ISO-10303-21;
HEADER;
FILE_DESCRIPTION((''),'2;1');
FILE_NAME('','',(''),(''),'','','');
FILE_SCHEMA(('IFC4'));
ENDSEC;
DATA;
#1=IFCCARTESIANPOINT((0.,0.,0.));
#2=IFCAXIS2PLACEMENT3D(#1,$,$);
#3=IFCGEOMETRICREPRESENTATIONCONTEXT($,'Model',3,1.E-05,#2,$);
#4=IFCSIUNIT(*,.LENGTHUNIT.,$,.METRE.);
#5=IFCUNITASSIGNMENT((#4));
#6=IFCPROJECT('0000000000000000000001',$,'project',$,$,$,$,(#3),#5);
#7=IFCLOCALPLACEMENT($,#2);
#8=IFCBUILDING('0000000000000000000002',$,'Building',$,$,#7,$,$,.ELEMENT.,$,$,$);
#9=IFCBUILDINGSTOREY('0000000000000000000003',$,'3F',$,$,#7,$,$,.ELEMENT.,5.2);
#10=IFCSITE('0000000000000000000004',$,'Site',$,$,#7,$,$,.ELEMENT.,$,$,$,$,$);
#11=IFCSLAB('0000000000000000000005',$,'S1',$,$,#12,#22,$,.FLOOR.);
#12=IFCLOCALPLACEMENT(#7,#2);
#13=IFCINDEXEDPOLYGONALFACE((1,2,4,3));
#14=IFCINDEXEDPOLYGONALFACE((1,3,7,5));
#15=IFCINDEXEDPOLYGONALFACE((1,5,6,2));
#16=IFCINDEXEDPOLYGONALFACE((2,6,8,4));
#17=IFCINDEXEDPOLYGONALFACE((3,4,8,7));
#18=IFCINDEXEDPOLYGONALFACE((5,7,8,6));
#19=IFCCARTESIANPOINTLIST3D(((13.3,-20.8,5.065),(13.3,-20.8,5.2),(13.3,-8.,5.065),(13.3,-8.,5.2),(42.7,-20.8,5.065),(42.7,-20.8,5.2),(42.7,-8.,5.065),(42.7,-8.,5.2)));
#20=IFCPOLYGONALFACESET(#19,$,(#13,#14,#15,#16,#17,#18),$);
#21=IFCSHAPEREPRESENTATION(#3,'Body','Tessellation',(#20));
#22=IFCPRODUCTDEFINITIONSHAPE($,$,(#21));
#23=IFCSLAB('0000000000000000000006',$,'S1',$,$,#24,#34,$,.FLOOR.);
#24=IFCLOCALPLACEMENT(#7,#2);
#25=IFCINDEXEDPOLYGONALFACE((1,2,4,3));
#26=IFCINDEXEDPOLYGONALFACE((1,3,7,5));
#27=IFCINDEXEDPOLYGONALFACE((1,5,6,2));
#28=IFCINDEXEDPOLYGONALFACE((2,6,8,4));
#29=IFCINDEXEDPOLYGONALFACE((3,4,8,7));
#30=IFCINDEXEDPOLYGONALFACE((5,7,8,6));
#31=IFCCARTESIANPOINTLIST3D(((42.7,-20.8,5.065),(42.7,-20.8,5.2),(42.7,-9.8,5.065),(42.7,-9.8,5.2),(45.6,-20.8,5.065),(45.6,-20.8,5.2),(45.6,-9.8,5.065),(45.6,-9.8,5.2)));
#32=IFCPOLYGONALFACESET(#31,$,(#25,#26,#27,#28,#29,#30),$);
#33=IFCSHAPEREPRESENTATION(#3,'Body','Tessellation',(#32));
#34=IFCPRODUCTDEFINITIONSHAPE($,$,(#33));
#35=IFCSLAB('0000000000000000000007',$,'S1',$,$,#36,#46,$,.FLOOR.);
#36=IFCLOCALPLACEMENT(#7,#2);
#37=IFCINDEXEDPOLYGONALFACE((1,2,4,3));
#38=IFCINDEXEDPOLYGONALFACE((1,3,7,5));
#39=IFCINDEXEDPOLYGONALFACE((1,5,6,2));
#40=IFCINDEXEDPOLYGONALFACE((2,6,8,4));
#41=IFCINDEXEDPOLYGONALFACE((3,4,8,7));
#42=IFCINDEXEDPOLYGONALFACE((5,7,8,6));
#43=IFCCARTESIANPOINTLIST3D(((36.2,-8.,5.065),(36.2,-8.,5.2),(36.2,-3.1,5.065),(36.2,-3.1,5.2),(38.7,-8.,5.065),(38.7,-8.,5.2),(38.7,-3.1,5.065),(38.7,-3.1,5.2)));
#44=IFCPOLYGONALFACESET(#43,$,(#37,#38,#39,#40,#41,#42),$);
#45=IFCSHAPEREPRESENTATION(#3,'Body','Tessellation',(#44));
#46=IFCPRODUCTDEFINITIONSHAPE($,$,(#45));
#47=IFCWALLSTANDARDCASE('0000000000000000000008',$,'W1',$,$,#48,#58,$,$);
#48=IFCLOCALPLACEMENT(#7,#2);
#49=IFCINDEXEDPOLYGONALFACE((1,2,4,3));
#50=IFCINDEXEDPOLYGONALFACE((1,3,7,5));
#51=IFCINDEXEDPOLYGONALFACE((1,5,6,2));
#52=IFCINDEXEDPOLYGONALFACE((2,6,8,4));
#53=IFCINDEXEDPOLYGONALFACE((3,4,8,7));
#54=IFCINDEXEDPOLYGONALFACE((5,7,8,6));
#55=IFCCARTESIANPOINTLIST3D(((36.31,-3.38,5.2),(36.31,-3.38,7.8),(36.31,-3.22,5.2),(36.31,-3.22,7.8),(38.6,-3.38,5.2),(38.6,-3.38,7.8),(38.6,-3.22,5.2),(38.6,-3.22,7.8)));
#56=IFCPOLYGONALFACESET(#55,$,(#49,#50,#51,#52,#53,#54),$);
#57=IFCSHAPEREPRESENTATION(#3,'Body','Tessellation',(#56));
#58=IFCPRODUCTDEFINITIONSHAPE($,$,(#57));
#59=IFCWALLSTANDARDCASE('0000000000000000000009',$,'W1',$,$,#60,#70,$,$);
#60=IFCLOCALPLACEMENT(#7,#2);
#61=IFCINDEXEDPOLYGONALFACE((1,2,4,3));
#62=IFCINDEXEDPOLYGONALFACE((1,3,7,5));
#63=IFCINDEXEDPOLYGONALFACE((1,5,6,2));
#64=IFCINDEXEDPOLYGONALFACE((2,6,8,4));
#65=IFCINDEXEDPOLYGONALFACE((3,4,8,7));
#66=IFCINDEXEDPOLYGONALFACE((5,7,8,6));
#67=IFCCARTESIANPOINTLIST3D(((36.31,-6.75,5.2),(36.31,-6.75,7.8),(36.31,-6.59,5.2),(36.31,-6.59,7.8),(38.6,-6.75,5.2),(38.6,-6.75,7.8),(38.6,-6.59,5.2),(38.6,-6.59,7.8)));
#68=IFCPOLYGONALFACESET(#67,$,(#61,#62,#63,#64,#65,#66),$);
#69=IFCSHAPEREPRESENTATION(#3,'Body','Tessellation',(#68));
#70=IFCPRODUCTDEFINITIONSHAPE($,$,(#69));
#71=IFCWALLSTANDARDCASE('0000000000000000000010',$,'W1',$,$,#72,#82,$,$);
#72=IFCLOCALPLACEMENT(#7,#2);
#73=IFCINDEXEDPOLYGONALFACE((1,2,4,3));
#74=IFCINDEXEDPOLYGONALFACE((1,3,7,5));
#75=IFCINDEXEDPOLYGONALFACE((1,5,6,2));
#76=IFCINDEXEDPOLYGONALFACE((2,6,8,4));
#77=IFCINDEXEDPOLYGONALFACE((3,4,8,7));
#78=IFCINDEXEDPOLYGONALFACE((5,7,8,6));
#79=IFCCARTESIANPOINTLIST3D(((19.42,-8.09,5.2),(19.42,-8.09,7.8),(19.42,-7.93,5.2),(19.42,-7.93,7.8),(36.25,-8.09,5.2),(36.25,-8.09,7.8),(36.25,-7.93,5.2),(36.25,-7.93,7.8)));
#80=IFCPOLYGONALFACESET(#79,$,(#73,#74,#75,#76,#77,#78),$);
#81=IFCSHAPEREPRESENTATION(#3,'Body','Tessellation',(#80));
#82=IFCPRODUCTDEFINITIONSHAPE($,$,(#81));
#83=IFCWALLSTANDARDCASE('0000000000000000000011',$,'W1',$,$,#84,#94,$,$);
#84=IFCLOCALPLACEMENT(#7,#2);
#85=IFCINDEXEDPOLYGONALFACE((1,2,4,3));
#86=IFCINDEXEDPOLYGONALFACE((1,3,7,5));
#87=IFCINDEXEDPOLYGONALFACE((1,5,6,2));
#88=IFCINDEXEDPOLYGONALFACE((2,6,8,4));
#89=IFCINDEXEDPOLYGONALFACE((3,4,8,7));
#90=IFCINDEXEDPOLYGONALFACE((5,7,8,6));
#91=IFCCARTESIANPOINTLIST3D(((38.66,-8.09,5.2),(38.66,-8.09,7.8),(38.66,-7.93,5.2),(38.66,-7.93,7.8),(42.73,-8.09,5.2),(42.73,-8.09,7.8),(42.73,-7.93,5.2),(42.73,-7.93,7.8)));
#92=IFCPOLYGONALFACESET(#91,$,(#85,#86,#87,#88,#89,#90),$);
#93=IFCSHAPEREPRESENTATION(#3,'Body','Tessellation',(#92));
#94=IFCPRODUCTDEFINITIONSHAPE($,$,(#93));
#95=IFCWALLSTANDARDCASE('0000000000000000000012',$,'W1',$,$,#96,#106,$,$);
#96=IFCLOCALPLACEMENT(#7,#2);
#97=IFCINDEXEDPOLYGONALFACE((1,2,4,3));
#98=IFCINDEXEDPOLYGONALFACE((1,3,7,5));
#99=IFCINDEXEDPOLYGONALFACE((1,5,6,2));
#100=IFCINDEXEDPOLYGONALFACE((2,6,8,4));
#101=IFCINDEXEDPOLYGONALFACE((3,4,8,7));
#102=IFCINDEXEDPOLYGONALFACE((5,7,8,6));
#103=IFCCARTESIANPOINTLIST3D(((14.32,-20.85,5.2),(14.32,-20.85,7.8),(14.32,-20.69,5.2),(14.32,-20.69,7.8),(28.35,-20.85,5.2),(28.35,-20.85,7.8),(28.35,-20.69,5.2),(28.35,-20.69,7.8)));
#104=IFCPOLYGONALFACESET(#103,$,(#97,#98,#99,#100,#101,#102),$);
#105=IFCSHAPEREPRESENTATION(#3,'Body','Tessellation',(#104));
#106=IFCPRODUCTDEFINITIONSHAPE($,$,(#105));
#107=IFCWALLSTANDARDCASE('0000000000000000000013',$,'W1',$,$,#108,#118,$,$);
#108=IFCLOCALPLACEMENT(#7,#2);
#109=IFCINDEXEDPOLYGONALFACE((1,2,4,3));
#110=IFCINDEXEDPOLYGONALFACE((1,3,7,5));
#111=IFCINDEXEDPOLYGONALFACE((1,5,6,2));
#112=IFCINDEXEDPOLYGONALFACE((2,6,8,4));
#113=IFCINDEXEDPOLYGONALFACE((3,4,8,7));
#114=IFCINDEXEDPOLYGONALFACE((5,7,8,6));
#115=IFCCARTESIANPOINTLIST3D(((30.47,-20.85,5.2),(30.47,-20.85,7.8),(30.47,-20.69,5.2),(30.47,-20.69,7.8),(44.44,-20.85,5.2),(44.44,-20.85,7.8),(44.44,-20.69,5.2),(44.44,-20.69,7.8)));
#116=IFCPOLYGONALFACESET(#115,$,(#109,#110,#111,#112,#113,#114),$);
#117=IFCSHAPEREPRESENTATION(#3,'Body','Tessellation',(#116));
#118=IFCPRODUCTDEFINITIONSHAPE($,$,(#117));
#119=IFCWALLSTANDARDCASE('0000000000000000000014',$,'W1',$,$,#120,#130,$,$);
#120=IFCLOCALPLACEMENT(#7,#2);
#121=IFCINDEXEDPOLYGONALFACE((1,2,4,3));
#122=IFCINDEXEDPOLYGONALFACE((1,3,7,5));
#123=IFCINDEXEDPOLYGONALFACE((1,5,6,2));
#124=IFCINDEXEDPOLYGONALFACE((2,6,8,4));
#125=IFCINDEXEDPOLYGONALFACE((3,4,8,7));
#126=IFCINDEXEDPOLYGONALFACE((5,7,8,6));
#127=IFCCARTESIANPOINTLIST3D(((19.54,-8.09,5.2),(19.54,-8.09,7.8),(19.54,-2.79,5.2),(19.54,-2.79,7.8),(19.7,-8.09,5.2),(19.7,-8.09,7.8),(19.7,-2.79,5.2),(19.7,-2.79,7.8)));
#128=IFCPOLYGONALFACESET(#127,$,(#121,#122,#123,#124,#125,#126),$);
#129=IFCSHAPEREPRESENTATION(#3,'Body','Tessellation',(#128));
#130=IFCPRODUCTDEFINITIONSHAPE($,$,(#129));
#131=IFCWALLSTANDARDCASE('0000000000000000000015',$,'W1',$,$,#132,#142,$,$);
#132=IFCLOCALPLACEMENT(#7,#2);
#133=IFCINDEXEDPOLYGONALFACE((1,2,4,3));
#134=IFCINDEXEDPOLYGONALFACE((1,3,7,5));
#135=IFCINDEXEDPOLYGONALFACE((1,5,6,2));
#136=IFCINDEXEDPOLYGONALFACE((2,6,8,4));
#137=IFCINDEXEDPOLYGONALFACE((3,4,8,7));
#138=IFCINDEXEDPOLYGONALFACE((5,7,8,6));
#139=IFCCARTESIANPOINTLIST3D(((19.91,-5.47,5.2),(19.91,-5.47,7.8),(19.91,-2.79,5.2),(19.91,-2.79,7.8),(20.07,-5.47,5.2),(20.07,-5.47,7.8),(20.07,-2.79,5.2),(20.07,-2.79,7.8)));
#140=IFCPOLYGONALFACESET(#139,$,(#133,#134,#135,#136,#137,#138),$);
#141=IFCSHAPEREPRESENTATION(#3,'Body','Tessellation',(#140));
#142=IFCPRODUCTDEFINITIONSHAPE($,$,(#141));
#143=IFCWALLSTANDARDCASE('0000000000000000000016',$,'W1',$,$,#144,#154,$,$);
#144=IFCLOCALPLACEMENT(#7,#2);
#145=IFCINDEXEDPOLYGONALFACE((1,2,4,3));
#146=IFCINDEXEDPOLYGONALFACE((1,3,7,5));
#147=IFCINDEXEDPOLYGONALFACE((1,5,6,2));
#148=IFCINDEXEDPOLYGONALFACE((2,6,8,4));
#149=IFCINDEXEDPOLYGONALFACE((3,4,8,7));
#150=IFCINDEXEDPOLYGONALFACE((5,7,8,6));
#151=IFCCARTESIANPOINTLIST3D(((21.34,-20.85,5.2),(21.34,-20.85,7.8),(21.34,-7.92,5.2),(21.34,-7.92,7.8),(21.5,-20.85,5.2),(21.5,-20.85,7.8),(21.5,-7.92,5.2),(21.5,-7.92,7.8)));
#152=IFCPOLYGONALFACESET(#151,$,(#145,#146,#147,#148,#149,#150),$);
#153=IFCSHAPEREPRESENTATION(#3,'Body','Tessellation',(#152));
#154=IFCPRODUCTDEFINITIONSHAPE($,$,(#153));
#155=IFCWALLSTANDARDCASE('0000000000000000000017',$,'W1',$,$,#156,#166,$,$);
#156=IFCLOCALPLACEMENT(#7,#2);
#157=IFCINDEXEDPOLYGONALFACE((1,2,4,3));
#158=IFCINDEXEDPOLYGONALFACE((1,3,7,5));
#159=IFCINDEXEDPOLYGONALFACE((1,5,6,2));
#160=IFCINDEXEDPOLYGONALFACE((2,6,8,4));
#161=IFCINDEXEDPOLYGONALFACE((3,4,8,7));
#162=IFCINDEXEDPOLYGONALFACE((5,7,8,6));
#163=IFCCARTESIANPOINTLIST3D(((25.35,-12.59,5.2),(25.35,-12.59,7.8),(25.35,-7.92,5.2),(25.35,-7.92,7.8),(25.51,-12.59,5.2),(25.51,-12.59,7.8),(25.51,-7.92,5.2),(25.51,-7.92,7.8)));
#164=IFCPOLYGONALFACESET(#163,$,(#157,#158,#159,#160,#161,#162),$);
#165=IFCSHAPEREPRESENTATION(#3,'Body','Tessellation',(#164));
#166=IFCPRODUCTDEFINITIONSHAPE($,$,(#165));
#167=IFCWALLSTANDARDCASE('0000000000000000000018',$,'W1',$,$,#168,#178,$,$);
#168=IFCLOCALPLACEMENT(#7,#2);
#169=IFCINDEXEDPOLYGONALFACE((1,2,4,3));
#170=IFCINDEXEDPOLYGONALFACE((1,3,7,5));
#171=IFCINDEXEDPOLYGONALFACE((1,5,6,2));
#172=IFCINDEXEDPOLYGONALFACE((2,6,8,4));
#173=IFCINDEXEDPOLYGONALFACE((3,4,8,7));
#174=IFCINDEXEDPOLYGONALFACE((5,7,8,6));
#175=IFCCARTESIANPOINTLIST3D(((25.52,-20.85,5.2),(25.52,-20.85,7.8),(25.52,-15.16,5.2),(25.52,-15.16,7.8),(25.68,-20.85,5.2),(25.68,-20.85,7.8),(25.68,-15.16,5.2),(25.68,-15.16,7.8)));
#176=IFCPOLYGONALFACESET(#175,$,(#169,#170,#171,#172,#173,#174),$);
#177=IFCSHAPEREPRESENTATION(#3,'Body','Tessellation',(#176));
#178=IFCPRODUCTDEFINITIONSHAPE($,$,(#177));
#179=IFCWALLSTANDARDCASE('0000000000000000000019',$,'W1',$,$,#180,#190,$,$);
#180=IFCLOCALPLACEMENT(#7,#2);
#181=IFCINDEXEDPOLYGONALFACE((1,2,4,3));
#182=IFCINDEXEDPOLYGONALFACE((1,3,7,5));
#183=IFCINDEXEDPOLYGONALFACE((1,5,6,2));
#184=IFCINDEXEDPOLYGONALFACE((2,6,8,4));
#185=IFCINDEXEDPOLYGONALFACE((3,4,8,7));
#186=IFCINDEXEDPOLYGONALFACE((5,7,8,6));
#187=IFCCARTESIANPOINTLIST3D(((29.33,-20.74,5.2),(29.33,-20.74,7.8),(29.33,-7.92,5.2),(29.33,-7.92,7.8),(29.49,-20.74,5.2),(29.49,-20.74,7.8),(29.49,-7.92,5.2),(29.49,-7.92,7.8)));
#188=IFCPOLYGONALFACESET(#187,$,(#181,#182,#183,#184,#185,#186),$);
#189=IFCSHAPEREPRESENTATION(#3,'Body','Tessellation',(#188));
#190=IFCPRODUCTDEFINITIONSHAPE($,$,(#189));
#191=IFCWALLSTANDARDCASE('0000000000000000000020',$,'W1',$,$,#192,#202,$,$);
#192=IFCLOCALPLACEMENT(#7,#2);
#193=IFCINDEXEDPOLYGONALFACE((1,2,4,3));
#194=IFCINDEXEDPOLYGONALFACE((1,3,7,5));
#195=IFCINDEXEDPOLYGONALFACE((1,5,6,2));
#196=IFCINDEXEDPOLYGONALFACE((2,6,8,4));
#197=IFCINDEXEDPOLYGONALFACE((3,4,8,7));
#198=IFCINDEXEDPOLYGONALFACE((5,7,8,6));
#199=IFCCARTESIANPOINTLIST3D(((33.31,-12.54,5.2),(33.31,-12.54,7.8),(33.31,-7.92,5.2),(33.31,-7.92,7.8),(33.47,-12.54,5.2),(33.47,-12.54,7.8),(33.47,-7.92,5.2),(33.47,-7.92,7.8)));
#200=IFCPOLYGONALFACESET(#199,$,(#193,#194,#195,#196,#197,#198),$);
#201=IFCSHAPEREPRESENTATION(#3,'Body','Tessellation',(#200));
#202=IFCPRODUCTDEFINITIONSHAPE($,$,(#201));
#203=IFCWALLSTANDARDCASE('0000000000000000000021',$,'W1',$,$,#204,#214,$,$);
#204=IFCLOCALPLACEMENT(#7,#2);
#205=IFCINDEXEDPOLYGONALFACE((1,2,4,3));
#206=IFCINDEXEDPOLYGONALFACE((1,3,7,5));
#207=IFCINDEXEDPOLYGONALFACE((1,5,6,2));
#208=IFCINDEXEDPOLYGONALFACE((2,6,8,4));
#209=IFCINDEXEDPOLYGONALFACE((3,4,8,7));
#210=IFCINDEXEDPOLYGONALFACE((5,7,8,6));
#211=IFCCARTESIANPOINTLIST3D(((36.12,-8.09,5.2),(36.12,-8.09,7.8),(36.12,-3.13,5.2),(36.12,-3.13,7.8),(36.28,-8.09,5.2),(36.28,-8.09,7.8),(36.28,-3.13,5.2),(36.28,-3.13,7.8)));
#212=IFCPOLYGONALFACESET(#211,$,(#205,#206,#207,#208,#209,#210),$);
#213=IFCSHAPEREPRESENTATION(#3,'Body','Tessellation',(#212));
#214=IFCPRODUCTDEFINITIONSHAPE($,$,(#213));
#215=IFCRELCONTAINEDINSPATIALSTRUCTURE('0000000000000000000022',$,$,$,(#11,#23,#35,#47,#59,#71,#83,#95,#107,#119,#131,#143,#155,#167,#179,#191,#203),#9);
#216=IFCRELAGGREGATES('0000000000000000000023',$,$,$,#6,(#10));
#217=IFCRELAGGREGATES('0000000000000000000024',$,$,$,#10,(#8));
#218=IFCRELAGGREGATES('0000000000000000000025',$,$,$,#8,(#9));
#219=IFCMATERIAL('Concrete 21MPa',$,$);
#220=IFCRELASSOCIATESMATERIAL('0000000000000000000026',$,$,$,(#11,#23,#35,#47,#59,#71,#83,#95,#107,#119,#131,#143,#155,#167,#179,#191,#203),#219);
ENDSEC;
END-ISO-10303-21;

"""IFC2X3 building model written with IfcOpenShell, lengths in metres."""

from ifc_helpers import new_model, si_unit, frame, origin, origin_2d, place, context, project, spatial, rectangle, extrude, material, element, save


model = new_model("IFC2X3")

# Units and contexts
model_context = context("Model", 3, precision=1e-05, world=origin())
ifc_project = project(units=[si_unit("LENGTHUNIT", "METRE")], contexts=[model_context])

# Site, building, storey
placement = place(None, origin())
site = spatial("IfcSite", under=ifc_project, at=placement, Name="Site", CompositionType="ELEMENT")
building = spatial("IfcBuilding", under=site, at=placement, Name="Building", CompositionType="ELEMENT")
storey = spatial("IfcBuildingStorey", under=building, at=placement, Name="3F", CompositionType="ELEMENT", Elevation=5.2)

# Slabs
ifc_material_1 = material(Name="Concrete 21MPa")
slab_1_placement = place(None, frame((28.0, -14.4, 5.065)))
element("IfcSlab", 1, at=slab_1_placement, inside=storey, material=ifc_material_1, Name="S1", PredefinedType="FLOOR", context=model_context, shape_type="SweptSolid", body=[
    extrude(rectangle(XDim=29.4, YDim=12.8, at=origin_2d()), origin(), (0.0, 0.0, 1.0), 0.135),
])
slab_2_placement = place(None, frame((44.15, -15.3, 5.065)))
element("IfcSlab", 2, at=slab_2_placement, inside=storey, material=ifc_material_1, Name="S1", PredefinedType="FLOOR", context=model_context, shape_type="SweptSolid", body=[
    extrude(rectangle(XDim=2.9, YDim=11.0, at=origin_2d()), origin(), (0.0, 0.0, 1.0), 0.135),
])
slab_3_placement = place(None, frame((37.45, -5.55, 5.065)))
element("IfcSlab", 3, at=slab_3_placement, inside=storey, material=ifc_material_1, Name="S1", PredefinedType="FLOOR", context=model_context, shape_type="SweptSolid", body=[
    extrude(rectangle(XDim=2.5, YDim=4.9, at=origin_2d()), origin(), (0.0, 0.0, 1.0), 0.135),
])

# Walls
for number, where, name in (
    (4, (37.455, -3.3, 5.2), "W1"),
    (5, (37.455, -6.67, 5.2), "W1"),
):
    element("IfcWallStandardCase", number, at=place(None, frame(where)), inside=storey, material=ifc_material_1, Name=name, context=model_context, shape_type="SweptSolid", body=[
        extrude(rectangle(XDim=2.29, YDim=0.16, at=origin_2d()), origin(), (0.0, 0.0, 1.0), 2.6),
    ])
wall_1_placement = place(None, frame((27.835, -8.01, 5.2)))
element("IfcWallStandardCase", 6, at=wall_1_placement, inside=storey, material=ifc_material_1, Name="W1", context=model_context, shape_type="SweptSolid", body=[
    extrude(rectangle(XDim=16.83, YDim=0.16, at=origin_2d()), origin(), (0.0, 0.0, 1.0), 2.6),
])
wall_2_placement = place(None, frame((40.695, -8.01, 5.2)))
element("IfcWallStandardCase", 7, at=wall_2_placement, inside=storey, material=ifc_material_1, Name="W1", context=model_context, shape_type="SweptSolid", body=[
    extrude(rectangle(XDim=4.07, YDim=0.16, at=origin_2d()), origin(), (0.0, 0.0, 1.0), 2.6),
])
wall_3_placement = place(None, frame((21.335, -20.77, 5.2)))
element("IfcWallStandardCase", 8, at=wall_3_placement, inside=storey, material=ifc_material_1, Name="W1", context=model_context, shape_type="SweptSolid", body=[
    extrude(rectangle(XDim=14.03, YDim=0.16, at=origin_2d()), origin(), (0.0, 0.0, 1.0), 2.6),
])
wall_4_placement = place(None, frame((37.455, -20.77, 5.2)))
element("IfcWallStandardCase", 9, at=wall_4_placement, inside=storey, material=ifc_material_1, Name="W1", context=model_context, shape_type="SweptSolid", body=[
    extrude(rectangle(XDim=13.97, YDim=0.16, at=origin_2d()), origin(), (0.0, 0.0, 1.0), 2.6),
])
wall_5_placement = place(None, frame((19.62, -5.44, 5.2)))
element("IfcWallStandardCase", 10, at=wall_5_placement, inside=storey, material=ifc_material_1, Name="W1", context=model_context, shape_type="SweptSolid", body=[
    extrude(rectangle(XDim=0.16, YDim=5.3, at=origin_2d()), origin(), (0.0, 0.0, 1.0), 2.6),
])
wall_6_placement = place(None, frame((19.99, -4.13, 5.2)))
element("IfcWallStandardCase", 11, at=wall_6_placement, inside=storey, material=ifc_material_1, Name="W1", context=model_context, shape_type="SweptSolid", body=[
    extrude(rectangle(XDim=0.16, YDim=2.68, at=origin_2d()), origin(), (0.0, 0.0, 1.0), 2.6),
])
wall_7_placement = place(None, frame((21.42, -14.385, 5.2)))
element("IfcWallStandardCase", 12, at=wall_7_placement, inside=storey, material=ifc_material_1, Name="W1", context=model_context, shape_type="SweptSolid", body=[
    extrude(rectangle(XDim=0.16, YDim=12.93, at=origin_2d()), origin(), (0.0, 0.0, 1.0), 2.6),
])
wall_8_placement = place(None, frame((25.43, -10.255, 5.2)))
element("IfcWallStandardCase", 13, at=wall_8_placement, inside=storey, material=ifc_material_1, Name="W1", context=model_context, shape_type="SweptSolid", body=[
    extrude(rectangle(XDim=0.16, YDim=4.67, at=origin_2d()), origin(), (0.0, 0.0, 1.0), 2.6),
])
wall_9_placement = place(None, frame((25.6, -18.005, 5.2)))
element("IfcWallStandardCase", 14, at=wall_9_placement, inside=storey, material=ifc_material_1, Name="W1", context=model_context, shape_type="SweptSolid", body=[
    extrude(rectangle(XDim=0.16, YDim=5.69, at=origin_2d()), origin(), (0.0, 0.0, 1.0), 2.6),
])
wall_10_placement = place(None, frame((29.41, -14.33, 5.2)))
element("IfcWallStandardCase", 15, at=wall_10_placement, inside=storey, material=ifc_material_1, Name="W1", context=model_context, shape_type="SweptSolid", body=[
    extrude(rectangle(XDim=0.16, YDim=12.82, at=origin_2d()), origin(), (0.0, 0.0, 1.0), 2.6),
])
wall_11_placement = place(None, frame((33.39, -10.23, 5.2)))
element("IfcWallStandardCase", 16, at=wall_11_placement, inside=storey, material=ifc_material_1, Name="W1", context=model_context, shape_type="SweptSolid", body=[
    extrude(rectangle(XDim=0.16, YDim=4.62, at=origin_2d()), origin(), (0.0, 0.0, 1.0), 2.6),
])
wall_12_placement = place(None, frame((36.2, -5.61, 5.2)))
element("IfcWallStandardCase", 17, at=wall_12_placement, inside=storey, material=ifc_material_1, Name="W1", context=model_context, shape_type="SweptSolid", body=[
    extrude(rectangle(XDim=0.16, YDim=4.96, at=origin_2d()), origin(), (0.0, 0.0, 1.0), 2.6),
])

save(model, "model.ifc")
